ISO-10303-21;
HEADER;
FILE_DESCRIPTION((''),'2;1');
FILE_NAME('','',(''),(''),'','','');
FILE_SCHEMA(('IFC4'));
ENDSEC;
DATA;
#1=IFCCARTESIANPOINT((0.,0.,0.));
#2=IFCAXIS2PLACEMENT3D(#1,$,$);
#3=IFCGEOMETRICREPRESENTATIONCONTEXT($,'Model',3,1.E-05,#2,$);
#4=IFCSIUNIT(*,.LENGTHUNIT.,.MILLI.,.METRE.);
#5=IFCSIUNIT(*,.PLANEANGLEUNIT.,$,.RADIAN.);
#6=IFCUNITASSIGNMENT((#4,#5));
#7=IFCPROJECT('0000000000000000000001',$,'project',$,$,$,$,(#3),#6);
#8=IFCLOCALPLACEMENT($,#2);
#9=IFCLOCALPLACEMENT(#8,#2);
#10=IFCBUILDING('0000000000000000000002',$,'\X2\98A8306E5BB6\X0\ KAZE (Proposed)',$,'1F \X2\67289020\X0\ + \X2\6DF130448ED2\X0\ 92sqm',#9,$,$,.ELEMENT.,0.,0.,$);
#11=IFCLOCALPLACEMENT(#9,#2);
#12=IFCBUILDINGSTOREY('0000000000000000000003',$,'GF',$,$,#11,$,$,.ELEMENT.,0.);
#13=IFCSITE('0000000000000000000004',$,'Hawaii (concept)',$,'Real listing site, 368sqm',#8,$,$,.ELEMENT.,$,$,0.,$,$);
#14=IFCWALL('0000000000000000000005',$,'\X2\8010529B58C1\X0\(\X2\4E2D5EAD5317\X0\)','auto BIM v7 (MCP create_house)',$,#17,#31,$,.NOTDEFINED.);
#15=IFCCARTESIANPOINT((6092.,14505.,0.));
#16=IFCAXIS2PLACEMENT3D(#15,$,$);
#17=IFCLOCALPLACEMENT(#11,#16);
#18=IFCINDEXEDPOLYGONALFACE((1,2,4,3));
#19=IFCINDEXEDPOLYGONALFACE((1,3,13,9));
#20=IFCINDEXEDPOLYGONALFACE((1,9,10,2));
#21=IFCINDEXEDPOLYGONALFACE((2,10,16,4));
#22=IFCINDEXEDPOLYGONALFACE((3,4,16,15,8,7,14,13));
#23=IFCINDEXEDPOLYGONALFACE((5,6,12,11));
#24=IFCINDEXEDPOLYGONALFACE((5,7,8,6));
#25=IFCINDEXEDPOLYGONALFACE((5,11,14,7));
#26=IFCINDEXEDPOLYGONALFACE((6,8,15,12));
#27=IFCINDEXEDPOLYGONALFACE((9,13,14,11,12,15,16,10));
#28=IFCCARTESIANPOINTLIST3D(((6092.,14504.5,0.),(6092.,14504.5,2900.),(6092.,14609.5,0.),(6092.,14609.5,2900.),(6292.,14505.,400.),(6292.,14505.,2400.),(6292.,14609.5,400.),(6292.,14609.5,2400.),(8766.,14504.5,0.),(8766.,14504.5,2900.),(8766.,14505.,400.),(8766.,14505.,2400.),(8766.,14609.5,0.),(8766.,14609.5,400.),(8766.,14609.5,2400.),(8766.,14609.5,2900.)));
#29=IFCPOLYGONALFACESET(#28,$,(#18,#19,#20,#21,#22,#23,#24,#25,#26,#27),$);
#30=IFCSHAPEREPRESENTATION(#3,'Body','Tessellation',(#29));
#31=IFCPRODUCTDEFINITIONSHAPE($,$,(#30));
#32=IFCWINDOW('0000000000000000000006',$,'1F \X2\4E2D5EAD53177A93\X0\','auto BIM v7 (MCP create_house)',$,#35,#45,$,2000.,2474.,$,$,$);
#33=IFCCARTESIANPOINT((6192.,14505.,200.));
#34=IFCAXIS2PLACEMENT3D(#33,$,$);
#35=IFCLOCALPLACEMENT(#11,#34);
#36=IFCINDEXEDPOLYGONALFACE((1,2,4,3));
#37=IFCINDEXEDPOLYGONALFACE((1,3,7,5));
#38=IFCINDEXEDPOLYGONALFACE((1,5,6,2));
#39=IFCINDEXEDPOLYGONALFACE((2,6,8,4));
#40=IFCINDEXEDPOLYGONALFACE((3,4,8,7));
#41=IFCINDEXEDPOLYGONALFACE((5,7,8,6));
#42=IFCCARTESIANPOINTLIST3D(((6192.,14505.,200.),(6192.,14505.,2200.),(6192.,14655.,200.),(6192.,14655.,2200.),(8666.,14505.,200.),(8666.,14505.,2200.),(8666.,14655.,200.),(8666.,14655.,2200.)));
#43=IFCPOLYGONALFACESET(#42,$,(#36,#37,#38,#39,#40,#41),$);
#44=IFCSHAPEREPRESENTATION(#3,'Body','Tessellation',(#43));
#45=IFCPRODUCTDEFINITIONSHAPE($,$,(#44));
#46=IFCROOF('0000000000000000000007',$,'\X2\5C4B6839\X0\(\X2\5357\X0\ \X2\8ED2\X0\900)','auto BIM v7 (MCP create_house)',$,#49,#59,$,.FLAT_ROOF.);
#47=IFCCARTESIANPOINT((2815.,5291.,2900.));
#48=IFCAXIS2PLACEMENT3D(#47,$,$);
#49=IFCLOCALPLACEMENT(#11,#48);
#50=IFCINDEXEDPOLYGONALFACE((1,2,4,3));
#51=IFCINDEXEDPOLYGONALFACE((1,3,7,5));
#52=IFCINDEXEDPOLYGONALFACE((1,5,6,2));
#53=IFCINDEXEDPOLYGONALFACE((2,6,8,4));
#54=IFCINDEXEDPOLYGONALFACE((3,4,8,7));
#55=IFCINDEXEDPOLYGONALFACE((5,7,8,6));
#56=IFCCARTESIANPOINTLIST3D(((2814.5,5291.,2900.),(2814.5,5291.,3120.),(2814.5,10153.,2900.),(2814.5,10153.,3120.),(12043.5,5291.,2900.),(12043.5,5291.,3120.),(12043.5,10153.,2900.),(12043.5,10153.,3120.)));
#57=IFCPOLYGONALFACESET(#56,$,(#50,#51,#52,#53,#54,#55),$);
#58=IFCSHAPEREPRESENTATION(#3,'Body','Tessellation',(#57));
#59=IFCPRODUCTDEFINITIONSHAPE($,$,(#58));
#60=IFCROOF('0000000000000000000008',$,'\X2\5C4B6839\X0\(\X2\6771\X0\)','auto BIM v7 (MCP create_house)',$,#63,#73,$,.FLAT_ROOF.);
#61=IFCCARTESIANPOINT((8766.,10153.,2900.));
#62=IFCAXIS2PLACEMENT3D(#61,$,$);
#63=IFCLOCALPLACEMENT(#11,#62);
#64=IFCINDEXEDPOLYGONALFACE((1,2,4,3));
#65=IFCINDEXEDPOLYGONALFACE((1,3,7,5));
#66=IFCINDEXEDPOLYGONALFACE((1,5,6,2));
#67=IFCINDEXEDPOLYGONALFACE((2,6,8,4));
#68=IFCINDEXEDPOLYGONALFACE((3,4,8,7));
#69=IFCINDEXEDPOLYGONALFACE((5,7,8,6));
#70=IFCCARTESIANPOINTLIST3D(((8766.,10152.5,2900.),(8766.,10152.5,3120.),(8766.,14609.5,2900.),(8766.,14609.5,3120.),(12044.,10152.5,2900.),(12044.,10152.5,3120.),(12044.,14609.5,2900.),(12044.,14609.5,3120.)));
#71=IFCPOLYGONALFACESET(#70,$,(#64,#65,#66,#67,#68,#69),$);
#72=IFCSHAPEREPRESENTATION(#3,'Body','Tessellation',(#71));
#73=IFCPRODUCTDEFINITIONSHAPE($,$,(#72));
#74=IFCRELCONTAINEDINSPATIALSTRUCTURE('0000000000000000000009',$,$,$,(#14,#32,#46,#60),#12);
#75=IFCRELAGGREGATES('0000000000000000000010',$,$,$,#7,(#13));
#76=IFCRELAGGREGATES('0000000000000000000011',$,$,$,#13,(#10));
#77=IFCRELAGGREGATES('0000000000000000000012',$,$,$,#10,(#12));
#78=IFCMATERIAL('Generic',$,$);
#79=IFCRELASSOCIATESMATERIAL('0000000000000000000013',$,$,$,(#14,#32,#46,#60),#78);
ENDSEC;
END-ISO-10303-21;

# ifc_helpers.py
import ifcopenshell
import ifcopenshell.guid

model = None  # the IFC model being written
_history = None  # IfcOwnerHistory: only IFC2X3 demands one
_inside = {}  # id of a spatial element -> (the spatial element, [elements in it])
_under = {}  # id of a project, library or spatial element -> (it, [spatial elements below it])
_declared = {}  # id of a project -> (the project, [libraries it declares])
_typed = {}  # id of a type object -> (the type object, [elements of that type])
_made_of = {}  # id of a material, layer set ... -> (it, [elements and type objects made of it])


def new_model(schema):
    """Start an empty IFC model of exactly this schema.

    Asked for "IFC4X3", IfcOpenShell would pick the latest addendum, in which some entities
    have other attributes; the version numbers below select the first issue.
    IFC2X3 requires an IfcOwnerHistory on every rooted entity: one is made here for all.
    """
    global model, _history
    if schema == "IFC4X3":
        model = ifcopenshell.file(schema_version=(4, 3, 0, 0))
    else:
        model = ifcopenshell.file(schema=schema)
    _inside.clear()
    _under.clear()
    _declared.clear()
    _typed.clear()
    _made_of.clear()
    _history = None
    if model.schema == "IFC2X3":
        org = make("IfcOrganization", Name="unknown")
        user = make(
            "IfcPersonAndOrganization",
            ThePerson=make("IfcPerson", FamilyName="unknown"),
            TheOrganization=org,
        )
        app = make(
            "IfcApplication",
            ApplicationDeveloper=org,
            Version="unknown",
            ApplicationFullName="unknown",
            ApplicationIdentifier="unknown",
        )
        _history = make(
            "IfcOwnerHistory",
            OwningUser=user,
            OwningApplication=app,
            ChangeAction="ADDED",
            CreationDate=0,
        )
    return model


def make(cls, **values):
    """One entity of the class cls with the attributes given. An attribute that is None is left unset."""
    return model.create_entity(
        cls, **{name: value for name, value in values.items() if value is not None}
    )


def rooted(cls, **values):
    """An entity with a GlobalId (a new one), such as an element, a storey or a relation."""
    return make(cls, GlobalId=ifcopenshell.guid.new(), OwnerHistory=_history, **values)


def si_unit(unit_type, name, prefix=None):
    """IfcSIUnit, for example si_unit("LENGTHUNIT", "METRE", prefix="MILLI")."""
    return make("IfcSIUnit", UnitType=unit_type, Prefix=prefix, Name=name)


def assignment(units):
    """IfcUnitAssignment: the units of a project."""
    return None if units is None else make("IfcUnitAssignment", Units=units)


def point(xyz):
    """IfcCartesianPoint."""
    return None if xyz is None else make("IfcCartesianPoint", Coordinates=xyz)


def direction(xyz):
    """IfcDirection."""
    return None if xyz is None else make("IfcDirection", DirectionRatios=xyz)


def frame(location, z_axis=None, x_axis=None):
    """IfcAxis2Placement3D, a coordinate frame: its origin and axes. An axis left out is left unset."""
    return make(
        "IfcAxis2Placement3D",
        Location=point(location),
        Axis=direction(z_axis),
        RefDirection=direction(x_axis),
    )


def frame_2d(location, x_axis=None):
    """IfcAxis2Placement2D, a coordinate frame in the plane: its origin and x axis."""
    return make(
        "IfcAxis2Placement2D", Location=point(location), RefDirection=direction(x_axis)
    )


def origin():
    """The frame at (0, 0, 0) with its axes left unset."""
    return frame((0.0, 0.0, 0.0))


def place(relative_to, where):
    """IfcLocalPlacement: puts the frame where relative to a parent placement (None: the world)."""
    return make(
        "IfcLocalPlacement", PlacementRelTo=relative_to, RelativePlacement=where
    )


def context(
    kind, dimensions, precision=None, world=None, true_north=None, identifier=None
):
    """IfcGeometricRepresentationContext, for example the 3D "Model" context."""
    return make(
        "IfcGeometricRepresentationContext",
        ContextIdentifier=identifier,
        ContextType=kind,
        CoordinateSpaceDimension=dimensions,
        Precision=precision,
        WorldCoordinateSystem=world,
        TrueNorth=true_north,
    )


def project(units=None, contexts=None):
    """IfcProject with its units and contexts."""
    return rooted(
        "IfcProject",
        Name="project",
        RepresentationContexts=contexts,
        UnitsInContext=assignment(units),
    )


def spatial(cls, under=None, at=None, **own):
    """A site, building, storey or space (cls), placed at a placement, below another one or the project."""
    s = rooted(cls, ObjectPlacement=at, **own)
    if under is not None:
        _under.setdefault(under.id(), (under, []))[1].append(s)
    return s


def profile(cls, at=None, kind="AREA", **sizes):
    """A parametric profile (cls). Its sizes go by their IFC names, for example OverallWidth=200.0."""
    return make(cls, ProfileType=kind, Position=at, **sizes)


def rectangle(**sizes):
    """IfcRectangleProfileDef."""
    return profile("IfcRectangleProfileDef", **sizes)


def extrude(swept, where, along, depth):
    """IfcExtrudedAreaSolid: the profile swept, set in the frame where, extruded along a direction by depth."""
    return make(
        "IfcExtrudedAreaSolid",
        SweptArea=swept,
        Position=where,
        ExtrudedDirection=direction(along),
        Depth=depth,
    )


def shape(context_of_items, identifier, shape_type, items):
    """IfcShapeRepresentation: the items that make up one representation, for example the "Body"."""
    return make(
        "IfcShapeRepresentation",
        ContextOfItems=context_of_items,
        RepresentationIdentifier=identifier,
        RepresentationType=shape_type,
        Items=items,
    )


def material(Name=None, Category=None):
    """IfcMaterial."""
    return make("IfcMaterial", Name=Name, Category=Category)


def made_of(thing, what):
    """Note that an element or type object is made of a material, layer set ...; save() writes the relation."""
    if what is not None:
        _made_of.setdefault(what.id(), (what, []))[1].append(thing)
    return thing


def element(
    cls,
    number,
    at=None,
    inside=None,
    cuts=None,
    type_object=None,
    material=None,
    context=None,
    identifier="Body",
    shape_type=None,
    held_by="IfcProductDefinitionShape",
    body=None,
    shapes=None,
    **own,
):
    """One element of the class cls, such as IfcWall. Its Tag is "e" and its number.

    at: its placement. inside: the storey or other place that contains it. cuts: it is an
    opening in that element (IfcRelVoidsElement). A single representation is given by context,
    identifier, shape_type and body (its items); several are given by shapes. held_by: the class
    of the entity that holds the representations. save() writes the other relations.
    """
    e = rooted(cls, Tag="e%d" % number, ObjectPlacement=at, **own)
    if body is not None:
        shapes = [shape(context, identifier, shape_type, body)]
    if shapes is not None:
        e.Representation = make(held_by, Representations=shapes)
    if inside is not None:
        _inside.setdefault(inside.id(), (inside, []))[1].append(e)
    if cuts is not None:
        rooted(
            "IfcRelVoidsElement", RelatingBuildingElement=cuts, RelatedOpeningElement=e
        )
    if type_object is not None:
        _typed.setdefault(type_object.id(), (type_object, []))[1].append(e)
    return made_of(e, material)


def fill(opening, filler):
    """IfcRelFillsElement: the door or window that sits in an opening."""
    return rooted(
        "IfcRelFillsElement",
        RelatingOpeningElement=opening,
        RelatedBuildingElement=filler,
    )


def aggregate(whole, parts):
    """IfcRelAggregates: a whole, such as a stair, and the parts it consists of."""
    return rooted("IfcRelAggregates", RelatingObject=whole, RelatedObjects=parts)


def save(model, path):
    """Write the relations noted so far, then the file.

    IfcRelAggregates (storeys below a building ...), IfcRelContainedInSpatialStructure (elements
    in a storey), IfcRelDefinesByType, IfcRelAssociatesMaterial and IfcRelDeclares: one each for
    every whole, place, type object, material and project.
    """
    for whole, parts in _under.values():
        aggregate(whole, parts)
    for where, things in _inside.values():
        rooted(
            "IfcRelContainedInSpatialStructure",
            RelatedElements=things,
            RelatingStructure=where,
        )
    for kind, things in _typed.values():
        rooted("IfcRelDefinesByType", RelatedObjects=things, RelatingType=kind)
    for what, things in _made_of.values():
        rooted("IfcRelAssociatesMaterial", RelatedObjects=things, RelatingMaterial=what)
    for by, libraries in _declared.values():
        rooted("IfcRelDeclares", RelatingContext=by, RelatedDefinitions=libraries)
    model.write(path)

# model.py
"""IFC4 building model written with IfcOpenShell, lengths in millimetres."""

from ifc_helpers import new_model, si_unit, frame, frame_2d, origin, place, context, project, spatial, rectangle, extrude, material, element, fill, save


model = new_model("IFC4")

# Units and contexts
model_context = context("Model", 3, precision=1e-05, world=origin())
ifc_project = project(units=[si_unit("LENGTHUNIT", "METRE", prefix="MILLI"), si_unit("PLANEANGLEUNIT", "RADIAN")], contexts=[model_context])

# Site, building, storey
site_placement = place(None, origin())
site = spatial("IfcSite", under=ifc_project, at=site_placement, Name="Hawaii (concept)", ObjectType="Real listing site, 368sqm", CompositionType="ELEMENT", RefElevation=0.0)
building_placement = place(site_placement, origin())
building = spatial("IfcBuilding", under=site, at=building_placement, Name="風の家 KAZE (Proposed)", ObjectType="1F 木造 + 深い軒 92sqm", CompositionType="ELEMENT", ElevationOfRefHeight=0.0, ElevationOfTerrain=0.0)
storey_placement = place(building_placement, origin())
storey = spatial("IfcBuildingStorey", under=building, at=storey_placement, Name="GF", CompositionType="ELEMENT", Elevation=0.0)

# Shared definitions
ifc_material = material(Name="Generic")

# Wall, opening, window
wall_1_placement = place(storey_placement, frame((6092.0, 14505.0, 0.0)))
wall_1 = element("IfcWall", 1, at=wall_1_placement, inside=storey, material=ifc_material, Name="耐力壁(中庭北)", Description="auto BIM v7 (MCP create_house)", PredefinedType="NOTDEFINED", context=model_context, shape_type="SweptSolid", body=[
    extrude(rectangle(XDim=2674.0, YDim=105.0, at=frame_2d((1337.0, 52.0))), frame((6092.0, 14505.0, 0.0)), (0.0, 0.0, 1.0), 2900.0),
])
opening_1_placement = place(storey_placement, frame((6192.0, 14505.0, 200.0)))
opening_1 = element("IfcOpeningElement", 2, at=opening_1_placement, cuts=wall_1, PredefinedType="NOTDEFINED", context=model_context, shape_type="SweptSolid", body=[
    extrude(rectangle(XDim=2474.0, YDim=150.0, at=frame_2d((1237.0, 75.0))), frame((6192.0, 14505.0, 200.0)), (0.0, 0.0, 1.0), 2000.0),
])
window_1_placement = place(storey_placement, frame((6192.0, 14505.0, 200.0)))
window_1 = element("IfcWindow", 3, at=window_1_placement, inside=storey, material=ifc_material, Name="1F 中庭北窓", Description="auto BIM v7 (MCP create_house)", OverallHeight=2000.0, OverallWidth=2474.0, context=model_context, shape_type="SweptSolid", body=[
    extrude(rectangle(XDim=2474.0, YDim=150.0, at=frame_2d((1237.0, 75.0))), frame((6192.0, 14505.0, 200.0)), (0.0, 0.0, 1.0), 2000.0),
])
fill(opening_1, window_1)

# Roofs
roof_1_placement = place(storey_placement, frame((2815.0, 5291.0, 2900.0)))
element("IfcRoof", 4, at=roof_1_placement, inside=storey, material=ifc_material, Name="屋根(南 軒900)", Description="auto BIM v7 (MCP create_house)", PredefinedType="FLAT_ROOF", context=model_context, shape_type="SweptSolid", body=[
    extrude(rectangle(XDim=9229.0, YDim=4862.0, at=frame_2d((4614.0, 2431.0))), frame((2815.0, 5291.0, 2900.0)), (0.0, 0.0, 1.0), 220.0),
])
roof_2_placement = place(storey_placement, frame((8766.0, 10153.0, 2900.0)))
element("IfcRoof", 5, at=roof_2_placement, inside=storey, material=ifc_material, Name="屋根(東)", Description="auto BIM v7 (MCP create_house)", PredefinedType="FLAT_ROOF", context=model_context, shape_type="SweptSolid", body=[
    extrude(rectangle(XDim=3278.0, YDim=4457.0, at=frame_2d((1639.0, 2228.0))), frame((8766.0, 10153.0, 2900.0)), (0.0, 0.0, 1.0), 220.0),
])

save(model, "model.ifc")
